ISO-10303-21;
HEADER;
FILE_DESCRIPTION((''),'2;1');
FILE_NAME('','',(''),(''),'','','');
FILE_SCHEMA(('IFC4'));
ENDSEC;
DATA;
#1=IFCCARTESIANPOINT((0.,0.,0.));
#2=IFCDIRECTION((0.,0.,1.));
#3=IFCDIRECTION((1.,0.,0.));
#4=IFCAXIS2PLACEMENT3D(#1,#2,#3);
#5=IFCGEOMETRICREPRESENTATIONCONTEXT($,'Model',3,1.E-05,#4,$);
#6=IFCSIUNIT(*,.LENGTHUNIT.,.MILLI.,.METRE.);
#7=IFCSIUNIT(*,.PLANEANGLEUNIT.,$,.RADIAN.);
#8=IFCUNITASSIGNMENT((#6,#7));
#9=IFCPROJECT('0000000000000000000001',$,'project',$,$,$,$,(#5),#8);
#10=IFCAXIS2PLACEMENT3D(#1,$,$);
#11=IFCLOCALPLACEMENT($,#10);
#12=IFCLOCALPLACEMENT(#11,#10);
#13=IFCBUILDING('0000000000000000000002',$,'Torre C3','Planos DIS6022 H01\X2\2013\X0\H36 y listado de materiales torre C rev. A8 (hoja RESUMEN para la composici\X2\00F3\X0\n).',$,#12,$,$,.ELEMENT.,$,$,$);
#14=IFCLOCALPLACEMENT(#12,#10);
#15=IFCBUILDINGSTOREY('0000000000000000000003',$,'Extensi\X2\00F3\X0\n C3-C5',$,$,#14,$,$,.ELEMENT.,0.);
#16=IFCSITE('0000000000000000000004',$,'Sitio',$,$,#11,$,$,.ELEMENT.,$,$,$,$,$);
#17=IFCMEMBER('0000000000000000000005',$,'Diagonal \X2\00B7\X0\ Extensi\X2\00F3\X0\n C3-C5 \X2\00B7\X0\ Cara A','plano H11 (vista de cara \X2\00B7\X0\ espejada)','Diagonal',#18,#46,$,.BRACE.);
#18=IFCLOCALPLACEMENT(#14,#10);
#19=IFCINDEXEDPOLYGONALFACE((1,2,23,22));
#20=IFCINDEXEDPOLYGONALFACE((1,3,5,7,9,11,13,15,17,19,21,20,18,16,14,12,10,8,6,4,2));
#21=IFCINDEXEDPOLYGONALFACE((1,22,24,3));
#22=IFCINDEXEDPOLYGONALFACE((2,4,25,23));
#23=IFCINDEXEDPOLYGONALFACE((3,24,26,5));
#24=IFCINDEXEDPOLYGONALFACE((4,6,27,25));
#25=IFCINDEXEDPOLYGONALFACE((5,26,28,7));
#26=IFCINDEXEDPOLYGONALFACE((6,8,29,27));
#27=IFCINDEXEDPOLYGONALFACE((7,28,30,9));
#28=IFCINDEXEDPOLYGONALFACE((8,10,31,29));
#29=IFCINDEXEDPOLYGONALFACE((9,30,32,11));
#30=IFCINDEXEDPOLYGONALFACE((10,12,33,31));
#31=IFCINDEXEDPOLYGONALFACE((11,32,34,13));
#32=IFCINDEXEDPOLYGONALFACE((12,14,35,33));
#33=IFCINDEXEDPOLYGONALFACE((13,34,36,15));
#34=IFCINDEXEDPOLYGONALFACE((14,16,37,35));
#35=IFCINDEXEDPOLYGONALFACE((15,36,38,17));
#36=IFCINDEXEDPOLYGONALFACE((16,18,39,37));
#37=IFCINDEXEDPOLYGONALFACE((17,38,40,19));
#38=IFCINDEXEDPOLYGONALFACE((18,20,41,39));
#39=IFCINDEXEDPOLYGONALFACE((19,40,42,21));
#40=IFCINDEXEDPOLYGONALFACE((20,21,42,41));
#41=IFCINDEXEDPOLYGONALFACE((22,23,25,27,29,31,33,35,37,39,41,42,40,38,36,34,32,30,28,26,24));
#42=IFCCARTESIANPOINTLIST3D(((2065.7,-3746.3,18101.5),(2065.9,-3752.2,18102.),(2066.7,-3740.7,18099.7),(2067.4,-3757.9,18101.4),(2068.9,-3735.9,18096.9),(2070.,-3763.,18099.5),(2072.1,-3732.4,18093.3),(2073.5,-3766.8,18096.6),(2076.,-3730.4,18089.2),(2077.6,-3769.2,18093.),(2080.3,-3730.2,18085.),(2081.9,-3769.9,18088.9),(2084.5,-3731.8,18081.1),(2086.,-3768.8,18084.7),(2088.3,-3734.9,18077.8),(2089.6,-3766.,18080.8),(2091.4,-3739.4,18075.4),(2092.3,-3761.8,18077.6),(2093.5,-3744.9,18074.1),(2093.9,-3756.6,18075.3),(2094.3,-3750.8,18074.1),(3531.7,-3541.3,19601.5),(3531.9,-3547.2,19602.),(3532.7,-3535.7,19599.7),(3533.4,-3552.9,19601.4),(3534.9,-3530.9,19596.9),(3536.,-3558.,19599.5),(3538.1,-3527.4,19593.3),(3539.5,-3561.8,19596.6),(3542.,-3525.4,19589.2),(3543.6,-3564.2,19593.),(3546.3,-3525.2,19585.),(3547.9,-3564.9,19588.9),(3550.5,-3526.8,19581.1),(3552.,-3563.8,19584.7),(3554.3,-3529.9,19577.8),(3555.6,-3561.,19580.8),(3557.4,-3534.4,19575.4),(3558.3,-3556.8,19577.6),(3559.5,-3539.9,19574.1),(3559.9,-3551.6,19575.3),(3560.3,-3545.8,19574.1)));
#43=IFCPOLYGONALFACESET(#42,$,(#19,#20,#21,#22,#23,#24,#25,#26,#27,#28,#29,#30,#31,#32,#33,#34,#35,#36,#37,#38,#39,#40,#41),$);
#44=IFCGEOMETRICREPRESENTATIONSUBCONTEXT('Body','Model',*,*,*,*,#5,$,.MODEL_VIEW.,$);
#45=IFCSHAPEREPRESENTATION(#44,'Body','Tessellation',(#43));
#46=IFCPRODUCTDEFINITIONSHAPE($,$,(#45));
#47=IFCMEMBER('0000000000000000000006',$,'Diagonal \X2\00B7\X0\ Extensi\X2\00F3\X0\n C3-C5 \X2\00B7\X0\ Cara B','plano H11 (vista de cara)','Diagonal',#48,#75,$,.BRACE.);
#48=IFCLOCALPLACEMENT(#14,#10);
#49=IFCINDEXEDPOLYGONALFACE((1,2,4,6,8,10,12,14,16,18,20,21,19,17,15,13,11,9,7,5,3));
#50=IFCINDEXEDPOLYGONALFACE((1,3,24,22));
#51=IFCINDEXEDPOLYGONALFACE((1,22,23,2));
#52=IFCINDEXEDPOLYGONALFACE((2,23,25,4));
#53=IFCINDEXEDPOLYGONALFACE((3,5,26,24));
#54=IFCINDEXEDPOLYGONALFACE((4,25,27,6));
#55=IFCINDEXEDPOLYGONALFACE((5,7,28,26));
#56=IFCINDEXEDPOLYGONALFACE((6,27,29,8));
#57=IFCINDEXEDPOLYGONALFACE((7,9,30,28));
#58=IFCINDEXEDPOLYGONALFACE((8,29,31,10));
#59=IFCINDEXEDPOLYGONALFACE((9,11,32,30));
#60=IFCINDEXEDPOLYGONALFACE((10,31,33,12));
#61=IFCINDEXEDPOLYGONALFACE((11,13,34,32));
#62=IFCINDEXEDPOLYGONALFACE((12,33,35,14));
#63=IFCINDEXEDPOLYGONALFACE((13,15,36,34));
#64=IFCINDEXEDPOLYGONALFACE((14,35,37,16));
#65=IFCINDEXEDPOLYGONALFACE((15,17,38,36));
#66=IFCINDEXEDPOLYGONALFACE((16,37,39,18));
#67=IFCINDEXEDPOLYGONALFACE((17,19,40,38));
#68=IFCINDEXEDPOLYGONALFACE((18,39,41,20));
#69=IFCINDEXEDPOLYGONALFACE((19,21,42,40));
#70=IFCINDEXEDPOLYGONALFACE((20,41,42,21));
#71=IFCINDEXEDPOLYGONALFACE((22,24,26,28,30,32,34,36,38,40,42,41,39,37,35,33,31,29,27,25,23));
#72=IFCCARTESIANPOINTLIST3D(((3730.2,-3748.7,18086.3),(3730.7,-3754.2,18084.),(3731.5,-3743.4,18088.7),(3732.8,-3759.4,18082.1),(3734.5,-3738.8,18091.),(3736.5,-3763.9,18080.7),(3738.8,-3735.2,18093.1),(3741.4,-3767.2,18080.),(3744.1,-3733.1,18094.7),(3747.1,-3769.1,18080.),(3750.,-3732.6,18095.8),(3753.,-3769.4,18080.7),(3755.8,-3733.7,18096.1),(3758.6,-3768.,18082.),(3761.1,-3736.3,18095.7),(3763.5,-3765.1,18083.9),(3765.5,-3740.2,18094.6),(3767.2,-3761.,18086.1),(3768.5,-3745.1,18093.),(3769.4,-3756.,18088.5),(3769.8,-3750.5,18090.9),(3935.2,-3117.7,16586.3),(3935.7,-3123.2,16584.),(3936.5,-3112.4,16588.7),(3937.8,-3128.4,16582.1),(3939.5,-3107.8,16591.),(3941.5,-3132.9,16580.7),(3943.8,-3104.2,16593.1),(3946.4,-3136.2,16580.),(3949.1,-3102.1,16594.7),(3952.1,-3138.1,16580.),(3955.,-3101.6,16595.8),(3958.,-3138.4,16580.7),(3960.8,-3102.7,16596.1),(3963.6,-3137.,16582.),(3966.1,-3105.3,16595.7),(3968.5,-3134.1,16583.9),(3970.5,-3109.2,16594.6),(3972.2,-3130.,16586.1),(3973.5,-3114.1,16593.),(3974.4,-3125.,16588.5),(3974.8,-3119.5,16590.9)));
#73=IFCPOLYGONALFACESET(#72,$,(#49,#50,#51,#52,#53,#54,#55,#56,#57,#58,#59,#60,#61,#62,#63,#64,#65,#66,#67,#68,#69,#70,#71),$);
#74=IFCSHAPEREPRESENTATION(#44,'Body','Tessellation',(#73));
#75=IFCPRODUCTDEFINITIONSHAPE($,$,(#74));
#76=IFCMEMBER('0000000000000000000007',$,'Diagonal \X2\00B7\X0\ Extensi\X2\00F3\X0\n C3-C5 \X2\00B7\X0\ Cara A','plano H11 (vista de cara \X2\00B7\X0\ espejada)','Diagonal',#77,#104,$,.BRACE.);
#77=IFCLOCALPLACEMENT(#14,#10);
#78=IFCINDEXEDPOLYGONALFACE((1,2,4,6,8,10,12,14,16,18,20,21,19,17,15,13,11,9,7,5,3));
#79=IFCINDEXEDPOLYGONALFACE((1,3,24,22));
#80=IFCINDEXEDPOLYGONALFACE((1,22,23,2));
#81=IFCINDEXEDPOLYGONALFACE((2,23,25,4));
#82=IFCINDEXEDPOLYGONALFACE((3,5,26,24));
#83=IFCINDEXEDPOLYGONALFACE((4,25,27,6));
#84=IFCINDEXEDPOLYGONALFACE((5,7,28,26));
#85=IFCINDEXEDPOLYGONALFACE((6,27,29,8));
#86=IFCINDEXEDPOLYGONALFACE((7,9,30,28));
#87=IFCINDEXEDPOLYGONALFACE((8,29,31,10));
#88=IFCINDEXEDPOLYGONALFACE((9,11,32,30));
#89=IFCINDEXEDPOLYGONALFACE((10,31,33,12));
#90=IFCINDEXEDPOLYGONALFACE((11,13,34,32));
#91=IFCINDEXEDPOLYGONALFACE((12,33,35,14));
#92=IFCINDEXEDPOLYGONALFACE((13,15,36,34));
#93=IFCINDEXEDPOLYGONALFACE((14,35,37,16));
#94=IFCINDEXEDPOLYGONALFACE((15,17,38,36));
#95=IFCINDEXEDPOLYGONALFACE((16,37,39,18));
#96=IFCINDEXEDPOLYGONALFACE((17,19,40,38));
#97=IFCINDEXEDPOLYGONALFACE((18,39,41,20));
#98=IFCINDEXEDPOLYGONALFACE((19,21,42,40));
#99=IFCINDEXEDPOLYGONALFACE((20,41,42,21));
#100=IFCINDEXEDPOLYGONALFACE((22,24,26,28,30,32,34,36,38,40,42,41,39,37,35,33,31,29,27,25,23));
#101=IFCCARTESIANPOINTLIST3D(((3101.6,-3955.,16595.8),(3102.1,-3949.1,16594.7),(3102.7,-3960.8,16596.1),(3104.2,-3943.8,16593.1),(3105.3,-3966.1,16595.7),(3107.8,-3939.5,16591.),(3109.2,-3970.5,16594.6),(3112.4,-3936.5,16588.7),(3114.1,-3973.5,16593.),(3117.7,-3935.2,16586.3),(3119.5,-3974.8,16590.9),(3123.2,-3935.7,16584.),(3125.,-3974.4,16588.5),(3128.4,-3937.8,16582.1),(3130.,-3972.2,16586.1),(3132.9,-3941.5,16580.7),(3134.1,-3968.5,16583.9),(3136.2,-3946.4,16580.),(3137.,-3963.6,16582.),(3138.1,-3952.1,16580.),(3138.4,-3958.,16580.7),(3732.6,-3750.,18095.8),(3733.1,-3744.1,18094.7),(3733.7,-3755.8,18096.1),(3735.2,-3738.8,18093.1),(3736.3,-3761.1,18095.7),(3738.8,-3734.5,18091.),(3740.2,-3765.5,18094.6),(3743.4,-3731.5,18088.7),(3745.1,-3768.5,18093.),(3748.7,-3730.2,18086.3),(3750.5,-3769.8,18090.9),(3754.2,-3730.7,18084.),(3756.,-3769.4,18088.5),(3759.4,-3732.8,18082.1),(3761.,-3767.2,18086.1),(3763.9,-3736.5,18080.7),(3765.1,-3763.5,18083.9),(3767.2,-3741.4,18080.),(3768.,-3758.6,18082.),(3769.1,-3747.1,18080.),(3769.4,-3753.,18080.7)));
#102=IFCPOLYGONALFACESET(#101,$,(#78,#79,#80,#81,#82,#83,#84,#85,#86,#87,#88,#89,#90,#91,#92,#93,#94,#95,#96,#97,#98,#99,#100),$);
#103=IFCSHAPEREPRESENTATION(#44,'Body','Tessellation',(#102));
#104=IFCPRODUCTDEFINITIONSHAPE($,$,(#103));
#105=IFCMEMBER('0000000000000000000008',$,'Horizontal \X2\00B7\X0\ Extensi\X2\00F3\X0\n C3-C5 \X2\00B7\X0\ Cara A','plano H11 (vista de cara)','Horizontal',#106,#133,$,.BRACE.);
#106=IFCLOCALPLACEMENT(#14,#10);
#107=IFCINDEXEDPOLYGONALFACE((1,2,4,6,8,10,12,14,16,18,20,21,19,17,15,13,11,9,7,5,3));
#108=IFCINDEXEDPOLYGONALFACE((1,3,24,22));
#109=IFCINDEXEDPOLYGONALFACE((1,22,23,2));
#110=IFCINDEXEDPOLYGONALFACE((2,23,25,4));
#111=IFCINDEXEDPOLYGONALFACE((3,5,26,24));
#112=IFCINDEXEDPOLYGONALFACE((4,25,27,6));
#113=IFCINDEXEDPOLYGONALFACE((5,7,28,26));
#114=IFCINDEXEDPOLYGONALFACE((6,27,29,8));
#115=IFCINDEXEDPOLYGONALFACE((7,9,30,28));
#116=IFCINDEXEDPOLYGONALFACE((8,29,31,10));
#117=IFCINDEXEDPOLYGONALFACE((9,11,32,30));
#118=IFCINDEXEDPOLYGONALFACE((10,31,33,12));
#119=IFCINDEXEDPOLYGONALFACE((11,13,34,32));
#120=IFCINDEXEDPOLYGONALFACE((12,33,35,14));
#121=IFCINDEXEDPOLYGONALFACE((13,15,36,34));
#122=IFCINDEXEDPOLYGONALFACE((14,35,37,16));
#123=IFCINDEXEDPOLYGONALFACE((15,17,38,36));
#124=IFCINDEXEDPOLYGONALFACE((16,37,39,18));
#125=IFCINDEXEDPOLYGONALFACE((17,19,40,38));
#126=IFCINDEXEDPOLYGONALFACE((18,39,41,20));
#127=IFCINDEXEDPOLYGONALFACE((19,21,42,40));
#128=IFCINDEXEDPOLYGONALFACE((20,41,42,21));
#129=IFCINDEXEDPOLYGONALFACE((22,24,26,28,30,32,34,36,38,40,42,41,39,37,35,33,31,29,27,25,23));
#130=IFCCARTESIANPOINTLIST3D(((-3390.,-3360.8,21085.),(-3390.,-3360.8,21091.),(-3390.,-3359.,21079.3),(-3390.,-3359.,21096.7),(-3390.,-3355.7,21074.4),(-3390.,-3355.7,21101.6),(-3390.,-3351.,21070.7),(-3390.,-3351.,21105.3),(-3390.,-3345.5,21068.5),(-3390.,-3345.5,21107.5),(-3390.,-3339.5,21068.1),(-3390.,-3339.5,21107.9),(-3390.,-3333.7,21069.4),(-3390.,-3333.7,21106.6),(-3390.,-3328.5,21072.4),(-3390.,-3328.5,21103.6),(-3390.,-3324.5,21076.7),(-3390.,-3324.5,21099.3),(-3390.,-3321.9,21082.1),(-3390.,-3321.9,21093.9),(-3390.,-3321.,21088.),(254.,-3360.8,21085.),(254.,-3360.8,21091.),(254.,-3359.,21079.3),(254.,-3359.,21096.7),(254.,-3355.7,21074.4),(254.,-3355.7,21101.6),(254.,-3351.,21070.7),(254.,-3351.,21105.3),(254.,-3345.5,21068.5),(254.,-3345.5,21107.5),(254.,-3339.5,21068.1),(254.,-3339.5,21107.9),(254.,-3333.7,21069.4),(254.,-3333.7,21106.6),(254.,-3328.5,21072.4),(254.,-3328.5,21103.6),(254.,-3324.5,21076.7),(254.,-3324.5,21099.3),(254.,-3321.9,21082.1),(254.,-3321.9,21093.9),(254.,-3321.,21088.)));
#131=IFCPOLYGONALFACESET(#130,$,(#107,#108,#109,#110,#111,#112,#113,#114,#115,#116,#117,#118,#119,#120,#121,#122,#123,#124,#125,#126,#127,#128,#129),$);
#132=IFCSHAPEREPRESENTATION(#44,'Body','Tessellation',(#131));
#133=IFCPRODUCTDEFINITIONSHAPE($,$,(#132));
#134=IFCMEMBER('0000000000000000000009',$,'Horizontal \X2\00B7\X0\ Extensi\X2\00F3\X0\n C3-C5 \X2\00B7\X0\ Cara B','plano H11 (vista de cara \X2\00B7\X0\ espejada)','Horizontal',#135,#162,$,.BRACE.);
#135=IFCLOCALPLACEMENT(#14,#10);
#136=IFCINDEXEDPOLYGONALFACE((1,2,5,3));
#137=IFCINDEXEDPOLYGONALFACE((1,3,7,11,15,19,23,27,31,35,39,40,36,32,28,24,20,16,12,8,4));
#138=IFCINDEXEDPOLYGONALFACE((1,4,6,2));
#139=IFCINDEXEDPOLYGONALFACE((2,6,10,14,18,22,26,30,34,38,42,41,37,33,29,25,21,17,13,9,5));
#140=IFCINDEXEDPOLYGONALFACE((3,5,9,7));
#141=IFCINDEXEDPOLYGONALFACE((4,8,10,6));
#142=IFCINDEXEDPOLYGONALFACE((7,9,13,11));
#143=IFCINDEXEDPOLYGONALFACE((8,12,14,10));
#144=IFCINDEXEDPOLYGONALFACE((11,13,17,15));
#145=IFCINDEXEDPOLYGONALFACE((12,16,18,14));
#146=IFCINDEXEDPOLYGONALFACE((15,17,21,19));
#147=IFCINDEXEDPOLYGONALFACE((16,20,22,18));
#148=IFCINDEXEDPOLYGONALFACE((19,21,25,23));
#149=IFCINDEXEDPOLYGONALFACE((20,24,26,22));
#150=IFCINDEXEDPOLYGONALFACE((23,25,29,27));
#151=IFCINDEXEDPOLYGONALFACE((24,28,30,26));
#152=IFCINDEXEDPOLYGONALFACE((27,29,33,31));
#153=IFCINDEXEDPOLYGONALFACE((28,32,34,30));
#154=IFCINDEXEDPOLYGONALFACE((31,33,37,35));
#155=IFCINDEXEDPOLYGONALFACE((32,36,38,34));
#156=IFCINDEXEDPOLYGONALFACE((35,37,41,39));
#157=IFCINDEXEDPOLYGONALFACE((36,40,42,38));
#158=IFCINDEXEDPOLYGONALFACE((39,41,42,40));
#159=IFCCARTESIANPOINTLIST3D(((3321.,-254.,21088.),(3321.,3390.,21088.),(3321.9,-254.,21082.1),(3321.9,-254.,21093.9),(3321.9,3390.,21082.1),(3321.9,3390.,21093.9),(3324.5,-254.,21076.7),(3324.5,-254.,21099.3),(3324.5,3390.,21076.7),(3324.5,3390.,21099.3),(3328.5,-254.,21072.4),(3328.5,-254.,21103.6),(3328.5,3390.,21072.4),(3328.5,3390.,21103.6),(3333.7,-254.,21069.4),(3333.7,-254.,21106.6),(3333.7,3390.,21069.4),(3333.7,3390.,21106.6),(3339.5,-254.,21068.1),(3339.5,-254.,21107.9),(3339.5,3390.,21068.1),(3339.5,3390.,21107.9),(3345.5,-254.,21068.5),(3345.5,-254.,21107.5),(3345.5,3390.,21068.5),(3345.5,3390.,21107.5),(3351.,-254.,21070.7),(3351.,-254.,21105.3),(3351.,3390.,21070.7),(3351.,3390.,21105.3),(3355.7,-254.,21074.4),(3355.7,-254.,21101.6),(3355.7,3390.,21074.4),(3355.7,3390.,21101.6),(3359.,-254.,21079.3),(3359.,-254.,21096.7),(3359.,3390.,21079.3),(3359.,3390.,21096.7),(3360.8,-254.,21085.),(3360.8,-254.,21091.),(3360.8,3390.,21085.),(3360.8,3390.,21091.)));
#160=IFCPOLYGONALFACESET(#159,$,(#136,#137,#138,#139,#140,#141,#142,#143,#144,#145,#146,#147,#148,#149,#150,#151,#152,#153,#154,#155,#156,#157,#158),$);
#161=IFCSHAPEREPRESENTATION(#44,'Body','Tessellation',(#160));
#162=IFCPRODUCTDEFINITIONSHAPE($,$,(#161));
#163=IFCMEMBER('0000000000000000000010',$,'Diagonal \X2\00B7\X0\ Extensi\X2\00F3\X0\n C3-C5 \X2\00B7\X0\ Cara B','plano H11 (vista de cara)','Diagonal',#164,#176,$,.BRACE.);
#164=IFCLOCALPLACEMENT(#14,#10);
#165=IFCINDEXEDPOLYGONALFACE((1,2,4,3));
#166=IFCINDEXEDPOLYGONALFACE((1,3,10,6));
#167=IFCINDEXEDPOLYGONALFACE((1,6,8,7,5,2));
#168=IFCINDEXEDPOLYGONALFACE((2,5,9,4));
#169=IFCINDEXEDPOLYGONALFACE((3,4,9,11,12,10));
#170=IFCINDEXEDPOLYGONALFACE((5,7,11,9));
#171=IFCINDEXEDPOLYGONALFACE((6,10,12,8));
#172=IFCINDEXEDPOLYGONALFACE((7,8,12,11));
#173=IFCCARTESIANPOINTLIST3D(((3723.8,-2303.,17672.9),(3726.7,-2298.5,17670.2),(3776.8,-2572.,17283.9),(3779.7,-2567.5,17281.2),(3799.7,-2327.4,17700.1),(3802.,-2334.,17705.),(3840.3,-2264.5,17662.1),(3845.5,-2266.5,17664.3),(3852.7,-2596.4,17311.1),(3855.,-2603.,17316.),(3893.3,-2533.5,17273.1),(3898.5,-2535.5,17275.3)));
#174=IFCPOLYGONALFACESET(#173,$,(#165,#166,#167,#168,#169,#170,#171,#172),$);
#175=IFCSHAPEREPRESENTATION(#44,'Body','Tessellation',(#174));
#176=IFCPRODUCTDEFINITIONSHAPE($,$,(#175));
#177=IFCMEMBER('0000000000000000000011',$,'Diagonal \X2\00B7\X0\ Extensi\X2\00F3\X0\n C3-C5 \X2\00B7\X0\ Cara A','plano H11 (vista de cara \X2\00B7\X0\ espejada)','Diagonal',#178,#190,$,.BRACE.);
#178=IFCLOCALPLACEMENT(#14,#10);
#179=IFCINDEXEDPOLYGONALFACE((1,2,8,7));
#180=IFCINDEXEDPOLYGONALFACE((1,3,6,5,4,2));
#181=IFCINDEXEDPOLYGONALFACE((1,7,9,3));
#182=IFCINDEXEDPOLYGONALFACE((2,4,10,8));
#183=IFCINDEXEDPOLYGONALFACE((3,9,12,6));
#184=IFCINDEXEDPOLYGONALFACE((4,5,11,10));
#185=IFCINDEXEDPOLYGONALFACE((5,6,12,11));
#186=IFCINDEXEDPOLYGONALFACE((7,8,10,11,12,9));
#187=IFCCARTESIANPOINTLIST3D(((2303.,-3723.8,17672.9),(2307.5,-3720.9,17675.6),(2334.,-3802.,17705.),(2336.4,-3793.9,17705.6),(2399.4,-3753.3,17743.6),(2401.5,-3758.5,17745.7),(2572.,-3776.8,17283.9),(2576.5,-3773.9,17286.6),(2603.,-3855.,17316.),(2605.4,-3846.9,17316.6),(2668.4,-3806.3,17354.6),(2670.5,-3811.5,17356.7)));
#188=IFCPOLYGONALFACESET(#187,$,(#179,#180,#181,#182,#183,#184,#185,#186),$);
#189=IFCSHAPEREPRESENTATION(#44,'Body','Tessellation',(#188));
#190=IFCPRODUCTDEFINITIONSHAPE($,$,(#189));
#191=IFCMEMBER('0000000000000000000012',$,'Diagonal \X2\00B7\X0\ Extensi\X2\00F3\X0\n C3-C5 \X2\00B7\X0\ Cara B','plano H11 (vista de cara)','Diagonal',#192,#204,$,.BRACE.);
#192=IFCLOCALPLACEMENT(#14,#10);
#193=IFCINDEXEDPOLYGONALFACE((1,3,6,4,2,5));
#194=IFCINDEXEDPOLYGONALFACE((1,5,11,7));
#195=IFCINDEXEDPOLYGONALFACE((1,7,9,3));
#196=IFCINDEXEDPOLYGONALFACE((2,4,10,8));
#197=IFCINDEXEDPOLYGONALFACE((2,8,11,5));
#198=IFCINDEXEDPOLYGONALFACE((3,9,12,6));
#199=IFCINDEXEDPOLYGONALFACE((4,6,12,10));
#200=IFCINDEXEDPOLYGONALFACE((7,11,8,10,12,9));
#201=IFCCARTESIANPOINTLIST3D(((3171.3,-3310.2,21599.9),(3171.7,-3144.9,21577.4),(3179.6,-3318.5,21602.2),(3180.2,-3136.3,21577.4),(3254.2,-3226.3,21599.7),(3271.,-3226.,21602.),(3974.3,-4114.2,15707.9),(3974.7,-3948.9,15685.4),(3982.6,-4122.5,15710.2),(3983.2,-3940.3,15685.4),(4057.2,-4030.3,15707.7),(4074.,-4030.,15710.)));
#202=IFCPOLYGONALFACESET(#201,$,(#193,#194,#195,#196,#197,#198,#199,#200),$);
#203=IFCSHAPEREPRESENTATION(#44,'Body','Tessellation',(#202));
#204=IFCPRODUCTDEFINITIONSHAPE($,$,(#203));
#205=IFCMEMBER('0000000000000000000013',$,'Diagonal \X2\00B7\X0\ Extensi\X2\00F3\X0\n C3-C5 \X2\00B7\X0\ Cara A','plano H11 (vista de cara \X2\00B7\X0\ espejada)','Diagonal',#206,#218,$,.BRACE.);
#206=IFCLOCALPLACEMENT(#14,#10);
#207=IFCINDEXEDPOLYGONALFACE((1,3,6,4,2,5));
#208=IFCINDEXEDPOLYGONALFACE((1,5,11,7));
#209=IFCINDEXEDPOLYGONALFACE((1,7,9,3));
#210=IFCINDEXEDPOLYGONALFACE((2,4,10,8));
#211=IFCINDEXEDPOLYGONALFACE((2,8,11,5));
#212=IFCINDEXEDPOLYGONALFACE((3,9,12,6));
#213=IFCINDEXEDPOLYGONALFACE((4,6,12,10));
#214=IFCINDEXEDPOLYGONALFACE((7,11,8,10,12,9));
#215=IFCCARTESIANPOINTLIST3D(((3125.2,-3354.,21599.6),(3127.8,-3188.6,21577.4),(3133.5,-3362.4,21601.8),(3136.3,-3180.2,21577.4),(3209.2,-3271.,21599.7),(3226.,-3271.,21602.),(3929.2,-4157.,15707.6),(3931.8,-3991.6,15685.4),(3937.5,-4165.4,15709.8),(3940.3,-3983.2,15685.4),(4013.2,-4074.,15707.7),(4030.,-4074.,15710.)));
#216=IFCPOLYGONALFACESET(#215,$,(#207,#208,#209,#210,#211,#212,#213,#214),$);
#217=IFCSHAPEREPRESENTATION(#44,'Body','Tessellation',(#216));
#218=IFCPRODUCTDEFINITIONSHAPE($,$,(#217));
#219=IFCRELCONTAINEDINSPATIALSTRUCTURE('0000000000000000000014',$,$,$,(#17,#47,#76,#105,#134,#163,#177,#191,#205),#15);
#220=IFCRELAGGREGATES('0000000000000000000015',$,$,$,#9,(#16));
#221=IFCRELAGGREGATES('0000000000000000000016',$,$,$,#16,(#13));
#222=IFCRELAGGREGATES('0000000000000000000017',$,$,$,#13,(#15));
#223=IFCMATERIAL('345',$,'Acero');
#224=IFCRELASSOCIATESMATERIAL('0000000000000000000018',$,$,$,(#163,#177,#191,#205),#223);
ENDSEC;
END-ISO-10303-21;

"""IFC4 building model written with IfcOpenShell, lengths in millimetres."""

from ifc_helpers import new_model, si_unit, frame, frame_2d, origin, origin_with_axes, place, context, subcontext, project, spatial, circle, l_section, extrude, material, element, save


model = new_model("IFC4")

# Units and contexts
model_context = context("Model", 3, precision=1e-05, world=origin_with_axes())
body_context = subcontext(model_context, "Body", "Model", "MODEL_VIEW")
ifc_project = project(units=[si_unit("LENGTHUNIT", "METRE", prefix="MILLI"), si_unit("PLANEANGLEUNIT", "RADIAN")], contexts=[model_context])

# Site, building, storey
site_placement = place(None, origin())
site = spatial("IfcSite", under=ifc_project, at=site_placement, Name="Sitio", CompositionType="ELEMENT")
building_placement = place(site_placement, origin())
building = spatial("IfcBuilding", under=site, at=building_placement, Name="Torre C3", Description="Planos DIS6022 H01–H36 y listado de materiales torre C rev. A8 (hoja RESUMEN para la composición).", CompositionType="ELEMENT")
storey_placement = place(building_placement, origin())
storey = spatial("IfcBuildingStorey", under=building, at=storey_placement, Name="Extensión C3-C5", CompositionType="ELEMENT", Elevation=0.0)

# Members
ifc_material_1 = material(Name="345", Category="Acero")
for number, where, z_axis, x_axis, name in (
    (1, (3546.0, -3545.0, 19588.0), (-0.69564, -0.097276, -0.711774), (-0.39331, 0.880677, 0.264036), "Diagonal · Extensión C3-C5 · Cara A"),
):
    element("IfcMember", number, at=place(storey_placement, frame(where, z_axis=z_axis, x_axis=x_axis)), inside=storey, Name=name, Description="plano H11 (vista de cara · espejada)", ObjectType="Diagonal", PredefinedType="BRACE", context=body_context, shape_type="SweptSolid", body=[
        extrude(circle(Radius=20.0), None, (0.0, 0.0, 1.0), 2107.4),
    ])
for number, where, z_axis, x_axis, name, description in (
    (2, (3750.0, -3751.0, 18088.0), (0.124986, 0.384714, -0.914535), (-0.777051, 0.61109, 0.150868), "Diagonal · Extensión C3-C5 · Cara B", "plano H11 (vista de cara)"),
    (3, (3751.0, -3750.0, 18088.0), (-0.384714, -0.124986, -0.914535), (-0.61109, 0.777051, 0.150868), "Diagonal · Extensión C3-C5 · Cara A", "plano H11 (vista de cara · espejada)"),
):
    element("IfcMember", number, at=place(storey_placement, frame(where, z_axis=z_axis, x_axis=x_axis)), inside=storey, Name=name, Description=description, ObjectType="Diagonal", PredefinedType="BRACE", context=body_context, shape_type="SweptSolid", body=[
        extrude(circle(Radius=20.0), None, (0.0, 0.0, 1.0), 1640.2),
    ])
for number, where, z_axis, x_axis, name, description in (
    (4, (254.0, -3341.0, 21088.0), (-1.0, 0.0, 0.0), (0.0, 1.0, 0.0), "Horizontal · Extensión C3-C5 · Cara A", "plano H11 (vista de cara)"),
    (5, (3341.0, -254.0, 21088.0), (0.0, 1.0, 0.0), (-1.0, 0.0, 0.0), "Horizontal · Extensión C3-C5 · Cara B", "plano H11 (vista de cara · espejada)"),
):
    element("IfcMember", number, at=place(storey_placement, frame(where, z_axis=z_axis, x_axis=x_axis)), inside=storey, Name=name, Description=description, ObjectType="Horizontal", PredefinedType="BRACE", context=body_context, shape_type="SweptSolid", body=[
        extrude(circle(Radius=20.0), None, (0.0, 0.0, 1.0), 3644.0),
    ])
for number, where, z_axis, x_axis, name, description in (
    (6, (3802.0, -2334.0, 17705.0), (0.111365, -0.565232, -0.81738), (-0.868367, 0.344616, -0.35662), "Diagonal · Extensión C3-C5 · Cara B", "plano H11 (vista de cara)"),
    (7, (2334.0, -3802.0, 17705.0), (0.565232, -0.111365, -0.81738), (-0.344616, 0.868367, -0.35662), "Diagonal · Extensión C3-C5 · Cara A", "plano H11 (vista de cara · espejada)"),
):
    element("IfcMember", number, at=place(storey_placement, frame(where, z_axis=z_axis, x_axis=x_axis)), inside=storey, material=ifc_material_1, Name=name, Description=description, ObjectType="Diagonal", PredefinedType="BRACE", context=body_context, shape_type="SweptSolid", body=[
        extrude(l_section(Depth=90.0, Width=90.0, Thickness=6.0, at=frame_2d((45.0, 45.0))), None, (0.0, 0.0, 1.0), 475.9),
    ])
for number, where, z_axis, x_axis, name, description in (
    (8, (4074.0, -4030.0, 15710.0), (-0.133821, 0.133987, 0.981906), (-0.698705, 0.689893, -0.189364), "Diagonal · Extensión C3-C5 · Cara B", "plano H11 (vista de cara)"),
    (9, (4030.0, -4074.0, 15710.0), (-0.133987, 0.133821, 0.981906), (-0.689893, 0.698705, -0.189364), "Diagonal · Extensión C3-C5 · Cara A", "plano H11 (vista de cara · espejada)"),
):
    element("IfcMember", number, at=place(storey_placement, frame(where, z_axis=z_axis, x_axis=x_axis)), inside=storey, material=ifc_material_1, Name=name, Description=description, ObjectType="Diagonal", PredefinedType="BRACE", context=body_context, shape_type="SweptSolid", body=[
        extrude(l_section(Depth=130.0, Width=130.0, Thickness=12.0, at=frame_2d((65.0, 65.0))), None, (0.0, 0.0, 1.0), 6000.6),
    ])

save(model, "model.ifc")
